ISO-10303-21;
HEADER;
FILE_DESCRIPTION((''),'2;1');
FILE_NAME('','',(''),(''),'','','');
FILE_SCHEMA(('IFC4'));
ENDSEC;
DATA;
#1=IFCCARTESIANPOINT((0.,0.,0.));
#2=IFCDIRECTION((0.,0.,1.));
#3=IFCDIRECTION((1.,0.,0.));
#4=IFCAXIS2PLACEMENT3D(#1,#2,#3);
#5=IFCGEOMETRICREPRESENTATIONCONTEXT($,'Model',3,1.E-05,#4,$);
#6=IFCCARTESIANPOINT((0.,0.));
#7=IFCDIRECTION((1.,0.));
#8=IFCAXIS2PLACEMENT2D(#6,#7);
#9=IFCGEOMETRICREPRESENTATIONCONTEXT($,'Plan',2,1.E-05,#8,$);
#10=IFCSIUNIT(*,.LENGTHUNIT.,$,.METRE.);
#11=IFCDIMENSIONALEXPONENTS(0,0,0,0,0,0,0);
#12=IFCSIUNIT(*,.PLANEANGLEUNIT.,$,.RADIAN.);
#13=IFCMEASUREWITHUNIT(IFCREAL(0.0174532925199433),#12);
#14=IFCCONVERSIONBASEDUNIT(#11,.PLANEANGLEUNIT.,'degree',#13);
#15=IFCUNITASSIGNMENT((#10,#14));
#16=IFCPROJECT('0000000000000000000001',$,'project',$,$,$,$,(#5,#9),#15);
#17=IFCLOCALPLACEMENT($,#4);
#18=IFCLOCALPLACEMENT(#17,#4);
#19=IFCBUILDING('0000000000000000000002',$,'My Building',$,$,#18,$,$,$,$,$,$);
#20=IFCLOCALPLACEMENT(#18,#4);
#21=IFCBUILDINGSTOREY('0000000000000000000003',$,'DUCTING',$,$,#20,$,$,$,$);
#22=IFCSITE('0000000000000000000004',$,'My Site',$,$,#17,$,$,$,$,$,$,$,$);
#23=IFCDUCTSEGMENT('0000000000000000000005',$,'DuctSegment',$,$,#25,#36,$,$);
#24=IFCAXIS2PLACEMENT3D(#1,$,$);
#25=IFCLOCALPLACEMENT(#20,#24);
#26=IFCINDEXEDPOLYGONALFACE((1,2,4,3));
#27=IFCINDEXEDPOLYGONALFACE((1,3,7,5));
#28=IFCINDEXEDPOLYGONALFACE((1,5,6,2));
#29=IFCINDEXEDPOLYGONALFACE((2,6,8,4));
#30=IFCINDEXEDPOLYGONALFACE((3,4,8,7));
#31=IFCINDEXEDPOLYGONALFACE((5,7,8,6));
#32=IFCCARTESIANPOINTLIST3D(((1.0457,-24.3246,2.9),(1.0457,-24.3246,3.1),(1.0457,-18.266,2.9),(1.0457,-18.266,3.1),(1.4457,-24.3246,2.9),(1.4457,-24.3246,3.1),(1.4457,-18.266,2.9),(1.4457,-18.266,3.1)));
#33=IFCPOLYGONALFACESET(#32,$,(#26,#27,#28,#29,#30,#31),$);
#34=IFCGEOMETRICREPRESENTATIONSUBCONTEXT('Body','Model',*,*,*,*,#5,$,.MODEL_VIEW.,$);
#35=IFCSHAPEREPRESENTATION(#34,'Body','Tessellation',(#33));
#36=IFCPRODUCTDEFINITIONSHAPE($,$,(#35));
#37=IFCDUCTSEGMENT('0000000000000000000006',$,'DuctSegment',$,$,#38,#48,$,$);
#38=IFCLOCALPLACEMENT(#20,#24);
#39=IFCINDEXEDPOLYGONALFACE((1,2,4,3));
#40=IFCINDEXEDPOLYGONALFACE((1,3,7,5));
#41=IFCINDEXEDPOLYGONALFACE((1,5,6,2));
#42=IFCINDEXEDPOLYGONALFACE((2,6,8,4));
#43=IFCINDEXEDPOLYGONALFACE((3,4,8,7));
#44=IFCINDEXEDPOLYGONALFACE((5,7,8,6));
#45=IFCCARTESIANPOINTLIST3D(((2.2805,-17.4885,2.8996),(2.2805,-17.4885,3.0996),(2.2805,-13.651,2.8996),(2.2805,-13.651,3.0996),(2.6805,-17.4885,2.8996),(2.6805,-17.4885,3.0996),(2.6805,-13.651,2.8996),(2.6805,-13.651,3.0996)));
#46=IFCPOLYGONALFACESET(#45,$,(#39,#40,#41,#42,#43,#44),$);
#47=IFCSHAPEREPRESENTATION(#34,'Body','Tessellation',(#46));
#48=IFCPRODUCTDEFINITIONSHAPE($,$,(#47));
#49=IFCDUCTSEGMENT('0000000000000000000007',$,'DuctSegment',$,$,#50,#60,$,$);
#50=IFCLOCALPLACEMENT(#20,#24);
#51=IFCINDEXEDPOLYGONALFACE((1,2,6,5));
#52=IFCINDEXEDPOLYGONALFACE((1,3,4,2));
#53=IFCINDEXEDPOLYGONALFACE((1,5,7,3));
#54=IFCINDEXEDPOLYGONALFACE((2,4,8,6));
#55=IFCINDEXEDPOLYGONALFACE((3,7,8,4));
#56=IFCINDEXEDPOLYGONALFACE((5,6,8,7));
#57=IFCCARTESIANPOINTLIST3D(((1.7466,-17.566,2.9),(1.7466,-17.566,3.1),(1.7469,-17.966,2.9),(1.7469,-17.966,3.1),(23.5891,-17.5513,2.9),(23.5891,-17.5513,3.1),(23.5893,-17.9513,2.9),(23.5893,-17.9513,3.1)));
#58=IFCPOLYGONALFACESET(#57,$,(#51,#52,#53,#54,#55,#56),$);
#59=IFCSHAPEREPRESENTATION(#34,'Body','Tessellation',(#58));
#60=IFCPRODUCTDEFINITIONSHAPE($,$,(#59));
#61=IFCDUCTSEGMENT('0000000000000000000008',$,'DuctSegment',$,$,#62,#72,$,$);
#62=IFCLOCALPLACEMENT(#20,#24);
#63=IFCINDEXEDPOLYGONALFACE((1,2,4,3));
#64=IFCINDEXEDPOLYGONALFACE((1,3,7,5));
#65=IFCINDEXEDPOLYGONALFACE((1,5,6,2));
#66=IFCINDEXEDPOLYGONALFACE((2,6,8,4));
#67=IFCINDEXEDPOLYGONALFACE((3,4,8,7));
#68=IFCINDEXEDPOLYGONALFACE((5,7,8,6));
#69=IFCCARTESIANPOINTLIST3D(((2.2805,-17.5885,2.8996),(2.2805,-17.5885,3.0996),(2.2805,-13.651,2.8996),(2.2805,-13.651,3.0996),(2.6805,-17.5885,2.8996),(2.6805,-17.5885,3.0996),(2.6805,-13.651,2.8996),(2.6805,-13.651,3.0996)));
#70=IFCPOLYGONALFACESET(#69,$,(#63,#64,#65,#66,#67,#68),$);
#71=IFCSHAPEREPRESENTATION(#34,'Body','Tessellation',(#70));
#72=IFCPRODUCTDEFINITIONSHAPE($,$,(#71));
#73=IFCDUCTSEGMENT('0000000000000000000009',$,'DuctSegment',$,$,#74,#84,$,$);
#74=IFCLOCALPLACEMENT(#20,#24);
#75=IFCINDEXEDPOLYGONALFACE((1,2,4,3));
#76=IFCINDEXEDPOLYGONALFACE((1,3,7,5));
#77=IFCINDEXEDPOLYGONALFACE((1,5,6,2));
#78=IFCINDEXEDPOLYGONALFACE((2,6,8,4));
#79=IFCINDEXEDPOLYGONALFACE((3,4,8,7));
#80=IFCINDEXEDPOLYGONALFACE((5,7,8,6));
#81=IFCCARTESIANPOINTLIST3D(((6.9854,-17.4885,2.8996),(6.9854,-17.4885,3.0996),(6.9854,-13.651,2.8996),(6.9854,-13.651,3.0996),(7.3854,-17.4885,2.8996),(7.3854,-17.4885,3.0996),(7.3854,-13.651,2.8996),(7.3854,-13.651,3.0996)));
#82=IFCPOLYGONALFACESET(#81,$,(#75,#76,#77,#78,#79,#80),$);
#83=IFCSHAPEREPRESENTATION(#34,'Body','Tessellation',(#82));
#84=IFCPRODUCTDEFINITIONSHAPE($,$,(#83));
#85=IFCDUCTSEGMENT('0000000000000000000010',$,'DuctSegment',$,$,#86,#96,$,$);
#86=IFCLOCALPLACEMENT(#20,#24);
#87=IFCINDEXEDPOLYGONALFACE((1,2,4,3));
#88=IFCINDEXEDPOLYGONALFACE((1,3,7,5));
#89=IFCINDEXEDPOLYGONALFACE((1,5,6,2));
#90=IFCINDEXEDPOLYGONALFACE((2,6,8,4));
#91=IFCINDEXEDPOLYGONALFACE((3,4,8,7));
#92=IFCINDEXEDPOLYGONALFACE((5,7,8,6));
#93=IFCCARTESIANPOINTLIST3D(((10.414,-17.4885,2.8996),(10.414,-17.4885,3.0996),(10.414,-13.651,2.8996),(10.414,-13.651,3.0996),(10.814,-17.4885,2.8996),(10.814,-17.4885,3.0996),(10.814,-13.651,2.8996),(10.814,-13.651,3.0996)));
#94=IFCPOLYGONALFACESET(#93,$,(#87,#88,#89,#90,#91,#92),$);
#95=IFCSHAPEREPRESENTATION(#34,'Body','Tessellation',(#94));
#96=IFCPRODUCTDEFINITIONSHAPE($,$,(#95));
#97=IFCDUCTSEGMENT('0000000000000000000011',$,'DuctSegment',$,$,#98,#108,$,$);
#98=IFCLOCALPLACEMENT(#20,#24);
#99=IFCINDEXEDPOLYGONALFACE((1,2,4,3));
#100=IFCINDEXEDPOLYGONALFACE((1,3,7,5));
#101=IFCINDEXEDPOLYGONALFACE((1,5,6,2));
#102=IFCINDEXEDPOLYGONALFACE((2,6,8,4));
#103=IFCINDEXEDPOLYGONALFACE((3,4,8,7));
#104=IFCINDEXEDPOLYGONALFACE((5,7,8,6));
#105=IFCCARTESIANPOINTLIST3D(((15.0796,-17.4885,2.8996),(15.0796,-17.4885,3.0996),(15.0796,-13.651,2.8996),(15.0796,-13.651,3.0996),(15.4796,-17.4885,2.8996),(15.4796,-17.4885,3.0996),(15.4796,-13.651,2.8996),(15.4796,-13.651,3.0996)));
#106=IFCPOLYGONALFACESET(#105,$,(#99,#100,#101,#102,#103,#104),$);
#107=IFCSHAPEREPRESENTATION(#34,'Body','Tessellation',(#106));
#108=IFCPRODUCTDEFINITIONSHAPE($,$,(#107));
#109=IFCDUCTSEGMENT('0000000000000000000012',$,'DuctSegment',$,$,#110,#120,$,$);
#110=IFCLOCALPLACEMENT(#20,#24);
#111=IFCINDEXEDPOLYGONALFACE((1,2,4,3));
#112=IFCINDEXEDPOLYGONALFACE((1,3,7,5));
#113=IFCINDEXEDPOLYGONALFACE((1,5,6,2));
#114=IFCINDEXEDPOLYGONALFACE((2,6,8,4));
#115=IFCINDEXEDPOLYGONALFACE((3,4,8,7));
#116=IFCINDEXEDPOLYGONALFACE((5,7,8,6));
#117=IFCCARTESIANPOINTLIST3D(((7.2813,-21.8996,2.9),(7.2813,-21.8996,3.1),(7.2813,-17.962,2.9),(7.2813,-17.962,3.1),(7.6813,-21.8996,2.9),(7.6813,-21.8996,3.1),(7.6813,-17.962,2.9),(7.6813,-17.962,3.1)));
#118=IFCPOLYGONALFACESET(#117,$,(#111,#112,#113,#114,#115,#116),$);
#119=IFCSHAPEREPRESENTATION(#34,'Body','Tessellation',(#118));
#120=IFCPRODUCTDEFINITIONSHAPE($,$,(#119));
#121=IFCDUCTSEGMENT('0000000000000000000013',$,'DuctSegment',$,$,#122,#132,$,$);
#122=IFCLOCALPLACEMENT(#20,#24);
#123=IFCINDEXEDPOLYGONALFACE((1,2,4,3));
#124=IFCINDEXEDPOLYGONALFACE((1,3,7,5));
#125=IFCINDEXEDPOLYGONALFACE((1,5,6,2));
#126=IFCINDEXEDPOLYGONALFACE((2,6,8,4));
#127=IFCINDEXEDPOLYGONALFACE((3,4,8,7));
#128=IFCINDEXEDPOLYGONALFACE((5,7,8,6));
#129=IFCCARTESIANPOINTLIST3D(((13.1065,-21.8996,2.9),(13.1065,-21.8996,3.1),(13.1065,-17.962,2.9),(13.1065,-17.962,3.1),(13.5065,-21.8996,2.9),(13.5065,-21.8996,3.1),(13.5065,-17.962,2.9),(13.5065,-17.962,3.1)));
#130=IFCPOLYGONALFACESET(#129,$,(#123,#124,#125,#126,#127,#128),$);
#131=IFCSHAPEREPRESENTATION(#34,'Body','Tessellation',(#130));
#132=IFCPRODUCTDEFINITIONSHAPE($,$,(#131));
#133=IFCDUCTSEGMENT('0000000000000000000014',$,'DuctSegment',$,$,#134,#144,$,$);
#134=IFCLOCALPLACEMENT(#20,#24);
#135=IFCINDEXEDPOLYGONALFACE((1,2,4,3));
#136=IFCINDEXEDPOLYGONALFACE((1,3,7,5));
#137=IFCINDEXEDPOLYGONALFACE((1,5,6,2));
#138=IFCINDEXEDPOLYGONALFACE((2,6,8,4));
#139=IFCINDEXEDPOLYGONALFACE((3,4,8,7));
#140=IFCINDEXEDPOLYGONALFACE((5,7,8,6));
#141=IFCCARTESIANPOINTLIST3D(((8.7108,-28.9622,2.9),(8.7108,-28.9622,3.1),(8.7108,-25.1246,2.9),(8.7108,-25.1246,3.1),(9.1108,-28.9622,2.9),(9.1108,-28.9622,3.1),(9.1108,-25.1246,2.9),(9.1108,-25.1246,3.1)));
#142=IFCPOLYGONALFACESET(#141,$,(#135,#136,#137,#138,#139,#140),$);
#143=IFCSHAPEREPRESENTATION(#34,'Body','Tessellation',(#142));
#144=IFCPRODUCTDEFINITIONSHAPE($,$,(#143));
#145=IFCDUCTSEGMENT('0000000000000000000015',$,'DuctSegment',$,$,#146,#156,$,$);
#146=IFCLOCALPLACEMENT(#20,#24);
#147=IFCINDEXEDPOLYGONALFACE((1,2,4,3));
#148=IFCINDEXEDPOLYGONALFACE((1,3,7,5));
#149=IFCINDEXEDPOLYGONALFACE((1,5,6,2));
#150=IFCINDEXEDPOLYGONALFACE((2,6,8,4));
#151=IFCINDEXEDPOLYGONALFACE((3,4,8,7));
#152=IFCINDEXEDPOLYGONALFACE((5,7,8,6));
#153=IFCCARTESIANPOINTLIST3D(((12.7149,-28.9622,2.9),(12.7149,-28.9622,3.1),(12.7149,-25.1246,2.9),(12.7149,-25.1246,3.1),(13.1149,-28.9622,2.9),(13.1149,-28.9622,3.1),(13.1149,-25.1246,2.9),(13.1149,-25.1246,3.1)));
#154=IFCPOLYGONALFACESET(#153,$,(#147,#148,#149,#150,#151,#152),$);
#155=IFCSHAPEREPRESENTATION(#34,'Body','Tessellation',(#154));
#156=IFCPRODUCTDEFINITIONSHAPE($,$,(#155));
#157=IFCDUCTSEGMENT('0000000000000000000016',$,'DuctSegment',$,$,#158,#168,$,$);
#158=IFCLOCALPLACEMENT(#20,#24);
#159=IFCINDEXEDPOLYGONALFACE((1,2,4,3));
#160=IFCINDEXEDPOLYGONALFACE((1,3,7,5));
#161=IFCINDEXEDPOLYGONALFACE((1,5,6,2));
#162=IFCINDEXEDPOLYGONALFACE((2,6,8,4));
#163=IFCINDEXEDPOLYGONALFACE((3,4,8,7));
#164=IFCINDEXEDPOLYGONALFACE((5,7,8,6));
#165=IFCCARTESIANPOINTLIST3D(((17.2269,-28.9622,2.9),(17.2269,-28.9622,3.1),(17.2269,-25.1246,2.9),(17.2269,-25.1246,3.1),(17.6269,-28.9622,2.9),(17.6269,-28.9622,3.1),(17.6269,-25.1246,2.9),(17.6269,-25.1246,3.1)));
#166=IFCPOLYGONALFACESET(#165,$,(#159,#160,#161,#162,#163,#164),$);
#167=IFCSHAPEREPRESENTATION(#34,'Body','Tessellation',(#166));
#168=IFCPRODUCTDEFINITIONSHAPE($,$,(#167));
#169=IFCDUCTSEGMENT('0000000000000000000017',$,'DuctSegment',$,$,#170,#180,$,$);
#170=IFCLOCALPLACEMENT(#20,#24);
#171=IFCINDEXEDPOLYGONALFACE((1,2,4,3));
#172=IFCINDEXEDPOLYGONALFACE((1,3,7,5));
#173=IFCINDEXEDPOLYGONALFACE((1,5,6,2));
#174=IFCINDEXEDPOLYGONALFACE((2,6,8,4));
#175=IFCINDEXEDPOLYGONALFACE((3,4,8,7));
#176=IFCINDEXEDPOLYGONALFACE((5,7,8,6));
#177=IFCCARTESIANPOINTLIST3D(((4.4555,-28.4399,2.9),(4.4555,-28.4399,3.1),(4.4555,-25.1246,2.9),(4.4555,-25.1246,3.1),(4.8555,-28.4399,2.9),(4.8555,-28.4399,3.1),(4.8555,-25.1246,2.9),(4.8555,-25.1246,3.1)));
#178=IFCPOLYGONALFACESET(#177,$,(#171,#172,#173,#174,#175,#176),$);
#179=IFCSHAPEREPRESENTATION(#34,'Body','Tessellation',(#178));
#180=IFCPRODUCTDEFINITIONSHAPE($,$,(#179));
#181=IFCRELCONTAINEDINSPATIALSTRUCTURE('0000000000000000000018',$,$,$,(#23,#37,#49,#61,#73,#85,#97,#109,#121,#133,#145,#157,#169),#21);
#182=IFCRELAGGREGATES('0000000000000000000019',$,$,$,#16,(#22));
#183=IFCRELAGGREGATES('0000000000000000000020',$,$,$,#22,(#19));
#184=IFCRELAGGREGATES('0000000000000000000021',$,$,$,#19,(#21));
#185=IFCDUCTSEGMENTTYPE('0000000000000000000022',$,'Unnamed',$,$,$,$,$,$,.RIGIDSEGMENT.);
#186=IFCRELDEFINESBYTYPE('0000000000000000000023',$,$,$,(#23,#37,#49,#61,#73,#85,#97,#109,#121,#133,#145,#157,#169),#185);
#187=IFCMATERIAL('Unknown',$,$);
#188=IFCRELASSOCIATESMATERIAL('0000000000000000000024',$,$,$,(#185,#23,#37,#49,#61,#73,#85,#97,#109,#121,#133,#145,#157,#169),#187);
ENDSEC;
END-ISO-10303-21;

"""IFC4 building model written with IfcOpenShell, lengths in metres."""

from ifc_helpers import new_model, entity, si_unit, converted_unit, frame, origin_with_axes, origin_2d_with_axis, place, context, subcontext, project, spatial, rectangle, extrude, material, material_profile, profile_set, profile_usage, type_object, element, save


model = new_model("IFC4")

# Units and contexts
model_context = context("Model", 3, precision=1e-05, world=origin_with_axes())
plan_context = context("Plan", 2, precision=1e-05, world=origin_2d_with_axis())
body_context = subcontext(model_context, "Body", "Model", "MODEL_VIEW")
ifc_project = project(units=[si_unit("LENGTHUNIT", "METRE"), converted_unit("PLANEANGLEUNIT", "degree", entity("IfcReal", 0.0174532925199433), si_unit("PLANEANGLEUNIT", "RADIAN"), dimensions=[0, 0, 0, 0, 0, 0, 0])], contexts=[model_context, plan_context])

# Site, building, storey
site_placement = place(None, origin_with_axes())
site = spatial("IfcSite", under=ifc_project, at=site_placement, Name="My Site")
building_placement = place(site_placement, origin_with_axes())
building = spatial("IfcBuilding", under=site, at=building_placement, Name="My Building")
storey_placement = place(building_placement, origin_with_axes())
storey = spatial("IfcBuildingStorey", under=building, at=storey_placement, Name="DUCTING")

# Duct segments
ifc_material = material(Name="Unknown")
ifc_material_profile_1 = material_profile(ifc_material, rectangle(XDim=0.4, YDim=0.2))
ifc_profile_set_1 = profile_set([ifc_material_profile_1])
ifc_profile_usage_1 = profile_usage(ifc_profile_set_1, cardinal=5)
duct_segment_type = type_object("IfcDuctSegmentType", Name="Unnamed", PredefinedType="RIGIDSEGMENT", material=ifc_profile_set_1)
duct_segment_1_placement = place(storey_placement, frame((1.2457, -24.3246, 3.0), z_axis=(0.0, 1.0, 0.0), x_axis=(-1.0, 0.0, 0.0)))
element("IfcDuctSegment", 1, at=duct_segment_1_placement, inside=storey, type_object=duct_segment_type, material=ifc_profile_usage_1, Name="DuctSegment", context=body_context, shape_type="SweptSolid", body=[
    extrude(rectangle(XDim=0.4, YDim=0.2), origin_with_axes(), (0.0, 0.0, 1.0), 6.0586),
])
ifc_profile_usage_2 = profile_usage(ifc_profile_set_1, cardinal=5)
duct_segment_2_placement = place(storey_placement, frame((2.4805, -17.4885, 2.9996), z_axis=(0.0, 1.0, 0.0), x_axis=(-1.0, 0.0, 0.0)))
element("IfcDuctSegment", 2, at=duct_segment_2_placement, inside=storey, type_object=duct_segment_type, material=ifc_profile_usage_2, Name="DuctSegment", context=body_context, shape_type="SweptSolid", body=[
    extrude(rectangle(XDim=0.4, YDim=0.2), origin_with_axes(), (0.0, 0.0, 1.0), 3.8375),
])
ifc_profile_usage_3 = profile_usage(ifc_profile_set_1, cardinal=5)
duct_segment_3_placement = place(storey_placement, frame((1.7467, -17.766, 3.0), z_axis=(1.0, 0.000674, 0.0), x_axis=(-0.000674, 1.0, 0.0)))
element("IfcDuctSegment", 3, at=duct_segment_3_placement, inside=storey, type_object=duct_segment_type, material=ifc_profile_usage_3, Name="DuctSegment", context=body_context, shape_type="SweptSolid", body=[
    extrude(rectangle(XDim=0.4, YDim=0.2), origin_with_axes(), (0.0, 0.0, 1.0), 21.8425),
])
ifc_profile_usage_4 = profile_usage(ifc_profile_set_1, cardinal=5)
duct_segment_4_placement = place(storey_placement, frame((2.4805, -17.5885, 2.9996), z_axis=(0.0, 1.0, 0.0), x_axis=(-1.0, 0.0, 0.0)))
element("IfcDuctSegment", 4, at=duct_segment_4_placement, inside=storey, type_object=duct_segment_type, material=ifc_profile_usage_4, Name="DuctSegment", context=body_context, shape_type="SweptSolid", body=[
    extrude(rectangle(XDim=0.4, YDim=0.2), origin_with_axes(), (0.0, 0.0, 1.0), 3.9375),
])
ifc_profile_usage_5 = profile_usage(ifc_profile_set_1, cardinal=5)
duct_segment_5_placement = place(storey_placement, frame((7.1854, -17.4885, 2.9996), z_axis=(0.0, 1.0, 0.0), x_axis=(-1.0, 0.0, 0.0)))
element("IfcDuctSegment", 5, at=duct_segment_5_placement, inside=storey, type_object=duct_segment_type, material=ifc_profile_usage_5, Name="DuctSegment", context=body_context, shape_type="SweptSolid", body=[
    extrude(rectangle(XDim=0.4, YDim=0.2), origin_with_axes(), (0.0, 0.0, 1.0), 3.8375),
])
ifc_profile_usage_6 = profile_usage(ifc_profile_set_1, cardinal=5)
duct_segment_6_placement = place(storey_placement, frame((10.614, -17.4885, 2.9996), z_axis=(0.0, 1.0, 0.0), x_axis=(-1.0, 0.0, 0.0)))
element("IfcDuctSegment", 6, at=duct_segment_6_placement, inside=storey, type_object=duct_segment_type, material=ifc_profile_usage_6, Name="DuctSegment", context=body_context, shape_type="SweptSolid", body=[
    extrude(rectangle(XDim=0.4, YDim=0.2), origin_with_axes(), (0.0, 0.0, 1.0), 3.8375),
])
ifc_profile_usage_7 = profile_usage(ifc_profile_set_1, cardinal=5)
duct_segment_7_placement = place(storey_placement, frame((15.2796, -17.4885, 2.9996), z_axis=(0.0, 1.0, 0.0), x_axis=(-1.0, 0.0, 0.0)))
element("IfcDuctSegment", 7, at=duct_segment_7_placement, inside=storey, type_object=duct_segment_type, material=ifc_profile_usage_7, Name="DuctSegment", context=body_context, shape_type="SweptSolid", body=[
    extrude(rectangle(XDim=0.4, YDim=0.2), origin_with_axes(), (0.0, 0.0, 1.0), 3.8375),
])
ifc_profile_usage_8 = profile_usage(ifc_profile_set_1, cardinal=5)
duct_segment_8_placement = place(storey_placement, frame((7.4813, -17.962, 3.0), z_axis=(0.0, -1.0, 0.0), x_axis=(1.0, 0.0, 0.0)))
element("IfcDuctSegment", 8, at=duct_segment_8_placement, inside=storey, type_object=duct_segment_type, material=ifc_profile_usage_8, Name="DuctSegment", context=body_context, shape_type="SweptSolid", body=[
    extrude(rectangle(XDim=0.4, YDim=0.2), origin_with_axes(), (0.0, 0.0, 1.0), 3.9375),
])
ifc_profile_usage_9 = profile_usage(ifc_profile_set_1, cardinal=5)
duct_segment_9_placement = place(storey_placement, frame((13.3065, -17.962, 3.0), z_axis=(0.0, -1.0, 0.0), x_axis=(1.0, 0.0, 0.0)))
element("IfcDuctSegment", 9, at=duct_segment_9_placement, inside=storey, type_object=duct_segment_type, material=ifc_profile_usage_9, Name="DuctSegment", context=body_context, shape_type="SweptSolid", body=[
    extrude(rectangle(XDim=0.4, YDim=0.2), origin_with_axes(), (0.0, 0.0, 1.0), 3.9375),
])
ifc_profile_usage_10 = profile_usage(ifc_profile_set_1, cardinal=5)
duct_segment_10_placement = place(storey_placement, frame((8.9108, -25.1246, 3.0), z_axis=(0.0, -1.0, 0.0), x_axis=(1.0, 0.0, 0.0)))
element("IfcDuctSegment", 10, at=duct_segment_10_placement, inside=storey, type_object=duct_segment_type, material=ifc_profile_usage_10, Name="DuctSegment", context=body_context, shape_type="SweptSolid", body=[
    extrude(rectangle(XDim=0.4, YDim=0.2), origin_with_axes(), (0.0, 0.0, 1.0), 3.8375),
])
ifc_profile_usage_11 = profile_usage(ifc_profile_set_1, cardinal=5)
duct_segment_11_placement = place(storey_placement, frame((12.9149, -25.1246, 3.0), z_axis=(0.0, -1.0, 0.0), x_axis=(1.0, 0.0, 0.0)))
element("IfcDuctSegment", 11, at=duct_segment_11_placement, inside=storey, type_object=duct_segment_type, material=ifc_profile_usage_11, Name="DuctSegment", context=body_context, shape_type="SweptSolid", body=[
    extrude(rectangle(XDim=0.4, YDim=0.2), origin_with_axes(), (0.0, 0.0, 1.0), 3.8375),
])
ifc_profile_usage_12 = profile_usage(ifc_profile_set_1, cardinal=5)
duct_segment_12_placement = place(storey_placement, frame((17.4269, -25.1246, 3.0), z_axis=(0.0, -1.0, 0.0), x_axis=(1.0, 0.0, 0.0)))
element("IfcDuctSegment", 12, at=duct_segment_12_placement, inside=storey, type_object=duct_segment_type, material=ifc_profile_usage_12, Name="DuctSegment", context=body_context, shape_type="SweptSolid", body=[
    extrude(rectangle(XDim=0.4, YDim=0.2), origin_with_axes(), (0.0, 0.0, 1.0), 3.8375),
])
ifc_profile_usage_13 = profile_usage(ifc_profile_set_1, cardinal=5)
duct_segment_13_placement = place(storey_placement, frame((4.6555, -25.1246, 3.0), z_axis=(0.0, -1.0, 0.0), x_axis=(1.0, 0.0, 0.0)))
element("IfcDuctSegment", 13, at=duct_segment_13_placement, inside=storey, type_object=duct_segment_type, material=ifc_profile_usage_13, Name="DuctSegment", context=body_context, shape_type="SweptSolid", body=[
    extrude(rectangle(XDim=0.4, YDim=0.2), origin_with_axes(), (0.0, 0.0, 1.0), 3.3152),
])

save(model, "model.ifc")
